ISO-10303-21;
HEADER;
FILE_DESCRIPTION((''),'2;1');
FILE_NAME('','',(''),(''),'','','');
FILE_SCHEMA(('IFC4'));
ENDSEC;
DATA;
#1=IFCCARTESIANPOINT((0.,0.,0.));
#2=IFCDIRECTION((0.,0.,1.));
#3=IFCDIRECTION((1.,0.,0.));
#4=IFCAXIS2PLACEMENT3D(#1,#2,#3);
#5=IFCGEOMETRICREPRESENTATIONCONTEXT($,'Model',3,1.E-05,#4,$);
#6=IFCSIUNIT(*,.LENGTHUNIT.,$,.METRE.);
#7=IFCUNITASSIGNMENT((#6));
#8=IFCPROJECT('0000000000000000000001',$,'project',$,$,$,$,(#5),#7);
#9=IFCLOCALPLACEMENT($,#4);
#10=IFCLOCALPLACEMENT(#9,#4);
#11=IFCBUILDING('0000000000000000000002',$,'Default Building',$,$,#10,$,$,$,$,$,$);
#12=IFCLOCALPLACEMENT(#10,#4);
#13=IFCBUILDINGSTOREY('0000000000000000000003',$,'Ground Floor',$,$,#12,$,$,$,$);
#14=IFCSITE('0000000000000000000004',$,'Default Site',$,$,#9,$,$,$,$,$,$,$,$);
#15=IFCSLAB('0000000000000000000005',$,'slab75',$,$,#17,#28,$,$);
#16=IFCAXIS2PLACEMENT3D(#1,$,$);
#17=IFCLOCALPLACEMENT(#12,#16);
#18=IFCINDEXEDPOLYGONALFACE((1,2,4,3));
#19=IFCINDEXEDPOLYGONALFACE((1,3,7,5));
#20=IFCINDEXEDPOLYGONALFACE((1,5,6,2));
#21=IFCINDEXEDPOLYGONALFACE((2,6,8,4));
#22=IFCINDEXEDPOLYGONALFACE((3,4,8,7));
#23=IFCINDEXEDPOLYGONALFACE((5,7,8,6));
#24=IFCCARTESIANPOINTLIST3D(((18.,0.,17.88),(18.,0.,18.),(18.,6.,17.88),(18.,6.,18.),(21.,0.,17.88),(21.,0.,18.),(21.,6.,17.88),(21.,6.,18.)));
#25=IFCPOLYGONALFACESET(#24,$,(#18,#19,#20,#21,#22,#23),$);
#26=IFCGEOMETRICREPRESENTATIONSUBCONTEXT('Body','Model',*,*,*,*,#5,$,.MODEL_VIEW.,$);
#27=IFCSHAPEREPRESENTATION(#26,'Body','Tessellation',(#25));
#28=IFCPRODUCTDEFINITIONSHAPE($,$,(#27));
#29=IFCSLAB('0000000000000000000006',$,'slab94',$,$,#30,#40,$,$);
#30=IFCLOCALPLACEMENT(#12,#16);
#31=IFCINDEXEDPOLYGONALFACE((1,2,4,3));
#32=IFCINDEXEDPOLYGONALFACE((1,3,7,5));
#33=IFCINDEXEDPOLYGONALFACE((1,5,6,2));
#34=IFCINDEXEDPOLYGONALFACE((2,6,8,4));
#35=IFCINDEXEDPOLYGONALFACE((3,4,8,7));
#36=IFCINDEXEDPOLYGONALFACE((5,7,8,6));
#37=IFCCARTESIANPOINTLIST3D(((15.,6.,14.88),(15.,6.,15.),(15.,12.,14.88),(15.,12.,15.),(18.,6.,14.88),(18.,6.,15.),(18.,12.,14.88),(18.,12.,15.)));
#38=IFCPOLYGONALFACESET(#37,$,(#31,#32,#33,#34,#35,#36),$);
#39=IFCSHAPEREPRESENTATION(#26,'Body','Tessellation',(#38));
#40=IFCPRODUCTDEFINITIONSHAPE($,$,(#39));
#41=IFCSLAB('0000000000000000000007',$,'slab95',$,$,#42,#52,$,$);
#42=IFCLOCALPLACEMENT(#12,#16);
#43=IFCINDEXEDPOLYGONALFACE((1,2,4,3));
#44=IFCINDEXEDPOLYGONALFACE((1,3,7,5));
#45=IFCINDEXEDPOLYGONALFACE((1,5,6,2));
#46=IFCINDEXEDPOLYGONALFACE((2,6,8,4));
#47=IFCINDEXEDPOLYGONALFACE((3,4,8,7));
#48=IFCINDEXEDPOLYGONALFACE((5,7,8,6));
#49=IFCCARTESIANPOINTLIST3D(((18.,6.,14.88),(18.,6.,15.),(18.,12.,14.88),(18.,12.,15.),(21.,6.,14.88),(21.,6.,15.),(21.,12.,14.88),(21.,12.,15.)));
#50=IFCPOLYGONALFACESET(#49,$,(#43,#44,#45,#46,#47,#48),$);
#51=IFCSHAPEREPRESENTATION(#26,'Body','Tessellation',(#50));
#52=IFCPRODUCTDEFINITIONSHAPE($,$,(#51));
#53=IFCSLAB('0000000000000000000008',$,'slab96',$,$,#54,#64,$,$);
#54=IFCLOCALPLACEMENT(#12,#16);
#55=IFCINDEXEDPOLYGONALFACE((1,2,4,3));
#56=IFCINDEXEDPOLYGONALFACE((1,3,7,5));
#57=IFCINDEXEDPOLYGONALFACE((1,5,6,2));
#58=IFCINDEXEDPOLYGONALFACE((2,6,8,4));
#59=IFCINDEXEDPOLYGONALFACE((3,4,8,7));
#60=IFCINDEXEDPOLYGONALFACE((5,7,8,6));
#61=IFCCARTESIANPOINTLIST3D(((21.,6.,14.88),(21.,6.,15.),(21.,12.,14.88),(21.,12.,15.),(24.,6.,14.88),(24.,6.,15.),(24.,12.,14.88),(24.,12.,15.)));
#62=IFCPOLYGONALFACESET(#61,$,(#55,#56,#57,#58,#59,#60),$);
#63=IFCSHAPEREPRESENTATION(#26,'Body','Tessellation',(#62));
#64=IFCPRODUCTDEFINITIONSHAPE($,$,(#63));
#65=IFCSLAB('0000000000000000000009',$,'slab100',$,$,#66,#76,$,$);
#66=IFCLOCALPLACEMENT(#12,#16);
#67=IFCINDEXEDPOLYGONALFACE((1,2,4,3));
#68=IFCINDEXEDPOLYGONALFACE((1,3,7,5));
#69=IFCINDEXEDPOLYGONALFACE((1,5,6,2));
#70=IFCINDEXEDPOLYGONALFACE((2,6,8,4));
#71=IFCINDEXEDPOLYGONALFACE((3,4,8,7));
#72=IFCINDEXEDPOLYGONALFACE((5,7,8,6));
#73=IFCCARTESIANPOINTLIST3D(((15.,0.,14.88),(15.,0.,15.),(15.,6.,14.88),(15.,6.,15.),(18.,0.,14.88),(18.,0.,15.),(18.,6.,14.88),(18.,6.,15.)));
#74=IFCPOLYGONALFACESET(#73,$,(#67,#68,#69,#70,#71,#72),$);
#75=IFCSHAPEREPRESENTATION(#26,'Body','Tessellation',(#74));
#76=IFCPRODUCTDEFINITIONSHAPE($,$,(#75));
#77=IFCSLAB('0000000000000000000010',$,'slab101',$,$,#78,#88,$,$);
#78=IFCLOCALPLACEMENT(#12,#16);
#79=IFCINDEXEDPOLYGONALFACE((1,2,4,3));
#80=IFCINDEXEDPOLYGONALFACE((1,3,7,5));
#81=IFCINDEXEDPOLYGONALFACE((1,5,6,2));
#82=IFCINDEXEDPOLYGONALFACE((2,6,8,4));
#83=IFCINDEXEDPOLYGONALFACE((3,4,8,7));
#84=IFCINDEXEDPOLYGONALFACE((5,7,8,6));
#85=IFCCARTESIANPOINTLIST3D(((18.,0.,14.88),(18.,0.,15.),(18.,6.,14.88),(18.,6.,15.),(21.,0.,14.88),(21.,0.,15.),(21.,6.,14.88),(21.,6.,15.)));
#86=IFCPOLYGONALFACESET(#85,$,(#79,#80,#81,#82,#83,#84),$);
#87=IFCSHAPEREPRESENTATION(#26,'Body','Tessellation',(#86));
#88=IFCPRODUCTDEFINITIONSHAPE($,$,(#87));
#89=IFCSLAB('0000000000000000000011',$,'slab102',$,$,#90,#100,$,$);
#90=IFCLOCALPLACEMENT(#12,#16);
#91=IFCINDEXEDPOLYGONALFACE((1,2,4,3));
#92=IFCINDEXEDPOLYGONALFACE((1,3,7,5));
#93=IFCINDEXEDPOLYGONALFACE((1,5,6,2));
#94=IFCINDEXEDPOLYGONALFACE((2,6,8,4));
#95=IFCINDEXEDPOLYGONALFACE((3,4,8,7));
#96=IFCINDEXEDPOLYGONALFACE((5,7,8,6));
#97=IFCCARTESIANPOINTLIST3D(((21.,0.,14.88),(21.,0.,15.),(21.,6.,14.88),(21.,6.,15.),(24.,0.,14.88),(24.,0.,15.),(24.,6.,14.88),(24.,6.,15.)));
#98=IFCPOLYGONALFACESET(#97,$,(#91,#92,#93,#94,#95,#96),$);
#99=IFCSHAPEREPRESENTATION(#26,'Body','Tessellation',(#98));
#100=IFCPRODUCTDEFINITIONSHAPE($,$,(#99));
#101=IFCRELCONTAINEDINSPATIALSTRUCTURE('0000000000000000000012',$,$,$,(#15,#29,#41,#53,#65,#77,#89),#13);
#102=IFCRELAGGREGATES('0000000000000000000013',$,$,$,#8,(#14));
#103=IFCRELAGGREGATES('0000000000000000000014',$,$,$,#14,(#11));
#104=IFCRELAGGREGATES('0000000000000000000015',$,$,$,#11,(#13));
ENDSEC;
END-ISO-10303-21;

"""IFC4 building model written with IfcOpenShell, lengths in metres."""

from ifc_helpers import new_model, si_unit, frame, origin_with_axes, place, context, subcontext, project, spatial, indexed_curve, outline, extrude, element, save


model = new_model("IFC4")

# Units and contexts
model_context = context("Model", 3, precision=1e-05, world=origin_with_axes())
body_context = subcontext(model_context, "Body", "Model", "MODEL_VIEW")
ifc_project = project(units=[si_unit("LENGTHUNIT", "METRE")], contexts=[model_context])

# Site, building, storey
site_placement = place(None, origin_with_axes())
site = spatial("IfcSite", under=ifc_project, at=site_placement, Name="Default Site")
building_placement = place(site_placement, origin_with_axes())
building = spatial("IfcBuilding", under=site, at=building_placement, Name="Default Building")
storey_placement = place(building_placement, origin_with_axes())
storey = spatial("IfcBuildingStorey", under=building, at=storey_placement, Name="Ground Floor")

# Slabs
for number, where, z_axis, x_axis, name in (
    (1, (18.0, 0.0, 17.88), (0.0, 0.0, 1.0), (1.0, 0.0, 0.0), "slab75"),
    (2, (15.0, 6.0, 14.88), (0.0, 0.0, 1.0), (1.0, 0.0, 0.0), "slab94"),
    (3, (18.0, 6.0, 14.88), (0.0, 0.0, 1.0), (1.0, 0.0, 0.0), "slab95"),
    (4, (21.0, 6.0, 14.88), (0.0, 0.0, 1.0), (1.0, 0.0, 0.0), "slab96"),
    (5, (15.0, 0.0, 14.88), (0.0, 0.0, 1.0), (1.0, 0.0, 0.0), "slab100"),
    (6, (18.0, 0.0, 14.88), (0.0, 0.0, 1.0), (1.0, 0.0, 0.0), "slab101"),
    (7, (21.0, 0.0, 14.88), (0.0, 0.0, 1.0), (1.0, 0.0, 0.0), "slab102"),
):
    element("IfcSlab", number, at=place(storey_placement, frame(where, z_axis=z_axis, x_axis=x_axis)), inside=storey, Name=name, context=body_context, shape_type="SweptSolid", body=[
        extrude(outline(indexed_curve([(0.0, 0.0), (0.0, 6.0), (3.0, 6.0), (3.0, 0.0), (0.0, 0.0)], self_intersect=False)), origin_with_axes(), (0.0, 0.0, 1.0), 0.12),
    ])

save(model, "model.ifc")
